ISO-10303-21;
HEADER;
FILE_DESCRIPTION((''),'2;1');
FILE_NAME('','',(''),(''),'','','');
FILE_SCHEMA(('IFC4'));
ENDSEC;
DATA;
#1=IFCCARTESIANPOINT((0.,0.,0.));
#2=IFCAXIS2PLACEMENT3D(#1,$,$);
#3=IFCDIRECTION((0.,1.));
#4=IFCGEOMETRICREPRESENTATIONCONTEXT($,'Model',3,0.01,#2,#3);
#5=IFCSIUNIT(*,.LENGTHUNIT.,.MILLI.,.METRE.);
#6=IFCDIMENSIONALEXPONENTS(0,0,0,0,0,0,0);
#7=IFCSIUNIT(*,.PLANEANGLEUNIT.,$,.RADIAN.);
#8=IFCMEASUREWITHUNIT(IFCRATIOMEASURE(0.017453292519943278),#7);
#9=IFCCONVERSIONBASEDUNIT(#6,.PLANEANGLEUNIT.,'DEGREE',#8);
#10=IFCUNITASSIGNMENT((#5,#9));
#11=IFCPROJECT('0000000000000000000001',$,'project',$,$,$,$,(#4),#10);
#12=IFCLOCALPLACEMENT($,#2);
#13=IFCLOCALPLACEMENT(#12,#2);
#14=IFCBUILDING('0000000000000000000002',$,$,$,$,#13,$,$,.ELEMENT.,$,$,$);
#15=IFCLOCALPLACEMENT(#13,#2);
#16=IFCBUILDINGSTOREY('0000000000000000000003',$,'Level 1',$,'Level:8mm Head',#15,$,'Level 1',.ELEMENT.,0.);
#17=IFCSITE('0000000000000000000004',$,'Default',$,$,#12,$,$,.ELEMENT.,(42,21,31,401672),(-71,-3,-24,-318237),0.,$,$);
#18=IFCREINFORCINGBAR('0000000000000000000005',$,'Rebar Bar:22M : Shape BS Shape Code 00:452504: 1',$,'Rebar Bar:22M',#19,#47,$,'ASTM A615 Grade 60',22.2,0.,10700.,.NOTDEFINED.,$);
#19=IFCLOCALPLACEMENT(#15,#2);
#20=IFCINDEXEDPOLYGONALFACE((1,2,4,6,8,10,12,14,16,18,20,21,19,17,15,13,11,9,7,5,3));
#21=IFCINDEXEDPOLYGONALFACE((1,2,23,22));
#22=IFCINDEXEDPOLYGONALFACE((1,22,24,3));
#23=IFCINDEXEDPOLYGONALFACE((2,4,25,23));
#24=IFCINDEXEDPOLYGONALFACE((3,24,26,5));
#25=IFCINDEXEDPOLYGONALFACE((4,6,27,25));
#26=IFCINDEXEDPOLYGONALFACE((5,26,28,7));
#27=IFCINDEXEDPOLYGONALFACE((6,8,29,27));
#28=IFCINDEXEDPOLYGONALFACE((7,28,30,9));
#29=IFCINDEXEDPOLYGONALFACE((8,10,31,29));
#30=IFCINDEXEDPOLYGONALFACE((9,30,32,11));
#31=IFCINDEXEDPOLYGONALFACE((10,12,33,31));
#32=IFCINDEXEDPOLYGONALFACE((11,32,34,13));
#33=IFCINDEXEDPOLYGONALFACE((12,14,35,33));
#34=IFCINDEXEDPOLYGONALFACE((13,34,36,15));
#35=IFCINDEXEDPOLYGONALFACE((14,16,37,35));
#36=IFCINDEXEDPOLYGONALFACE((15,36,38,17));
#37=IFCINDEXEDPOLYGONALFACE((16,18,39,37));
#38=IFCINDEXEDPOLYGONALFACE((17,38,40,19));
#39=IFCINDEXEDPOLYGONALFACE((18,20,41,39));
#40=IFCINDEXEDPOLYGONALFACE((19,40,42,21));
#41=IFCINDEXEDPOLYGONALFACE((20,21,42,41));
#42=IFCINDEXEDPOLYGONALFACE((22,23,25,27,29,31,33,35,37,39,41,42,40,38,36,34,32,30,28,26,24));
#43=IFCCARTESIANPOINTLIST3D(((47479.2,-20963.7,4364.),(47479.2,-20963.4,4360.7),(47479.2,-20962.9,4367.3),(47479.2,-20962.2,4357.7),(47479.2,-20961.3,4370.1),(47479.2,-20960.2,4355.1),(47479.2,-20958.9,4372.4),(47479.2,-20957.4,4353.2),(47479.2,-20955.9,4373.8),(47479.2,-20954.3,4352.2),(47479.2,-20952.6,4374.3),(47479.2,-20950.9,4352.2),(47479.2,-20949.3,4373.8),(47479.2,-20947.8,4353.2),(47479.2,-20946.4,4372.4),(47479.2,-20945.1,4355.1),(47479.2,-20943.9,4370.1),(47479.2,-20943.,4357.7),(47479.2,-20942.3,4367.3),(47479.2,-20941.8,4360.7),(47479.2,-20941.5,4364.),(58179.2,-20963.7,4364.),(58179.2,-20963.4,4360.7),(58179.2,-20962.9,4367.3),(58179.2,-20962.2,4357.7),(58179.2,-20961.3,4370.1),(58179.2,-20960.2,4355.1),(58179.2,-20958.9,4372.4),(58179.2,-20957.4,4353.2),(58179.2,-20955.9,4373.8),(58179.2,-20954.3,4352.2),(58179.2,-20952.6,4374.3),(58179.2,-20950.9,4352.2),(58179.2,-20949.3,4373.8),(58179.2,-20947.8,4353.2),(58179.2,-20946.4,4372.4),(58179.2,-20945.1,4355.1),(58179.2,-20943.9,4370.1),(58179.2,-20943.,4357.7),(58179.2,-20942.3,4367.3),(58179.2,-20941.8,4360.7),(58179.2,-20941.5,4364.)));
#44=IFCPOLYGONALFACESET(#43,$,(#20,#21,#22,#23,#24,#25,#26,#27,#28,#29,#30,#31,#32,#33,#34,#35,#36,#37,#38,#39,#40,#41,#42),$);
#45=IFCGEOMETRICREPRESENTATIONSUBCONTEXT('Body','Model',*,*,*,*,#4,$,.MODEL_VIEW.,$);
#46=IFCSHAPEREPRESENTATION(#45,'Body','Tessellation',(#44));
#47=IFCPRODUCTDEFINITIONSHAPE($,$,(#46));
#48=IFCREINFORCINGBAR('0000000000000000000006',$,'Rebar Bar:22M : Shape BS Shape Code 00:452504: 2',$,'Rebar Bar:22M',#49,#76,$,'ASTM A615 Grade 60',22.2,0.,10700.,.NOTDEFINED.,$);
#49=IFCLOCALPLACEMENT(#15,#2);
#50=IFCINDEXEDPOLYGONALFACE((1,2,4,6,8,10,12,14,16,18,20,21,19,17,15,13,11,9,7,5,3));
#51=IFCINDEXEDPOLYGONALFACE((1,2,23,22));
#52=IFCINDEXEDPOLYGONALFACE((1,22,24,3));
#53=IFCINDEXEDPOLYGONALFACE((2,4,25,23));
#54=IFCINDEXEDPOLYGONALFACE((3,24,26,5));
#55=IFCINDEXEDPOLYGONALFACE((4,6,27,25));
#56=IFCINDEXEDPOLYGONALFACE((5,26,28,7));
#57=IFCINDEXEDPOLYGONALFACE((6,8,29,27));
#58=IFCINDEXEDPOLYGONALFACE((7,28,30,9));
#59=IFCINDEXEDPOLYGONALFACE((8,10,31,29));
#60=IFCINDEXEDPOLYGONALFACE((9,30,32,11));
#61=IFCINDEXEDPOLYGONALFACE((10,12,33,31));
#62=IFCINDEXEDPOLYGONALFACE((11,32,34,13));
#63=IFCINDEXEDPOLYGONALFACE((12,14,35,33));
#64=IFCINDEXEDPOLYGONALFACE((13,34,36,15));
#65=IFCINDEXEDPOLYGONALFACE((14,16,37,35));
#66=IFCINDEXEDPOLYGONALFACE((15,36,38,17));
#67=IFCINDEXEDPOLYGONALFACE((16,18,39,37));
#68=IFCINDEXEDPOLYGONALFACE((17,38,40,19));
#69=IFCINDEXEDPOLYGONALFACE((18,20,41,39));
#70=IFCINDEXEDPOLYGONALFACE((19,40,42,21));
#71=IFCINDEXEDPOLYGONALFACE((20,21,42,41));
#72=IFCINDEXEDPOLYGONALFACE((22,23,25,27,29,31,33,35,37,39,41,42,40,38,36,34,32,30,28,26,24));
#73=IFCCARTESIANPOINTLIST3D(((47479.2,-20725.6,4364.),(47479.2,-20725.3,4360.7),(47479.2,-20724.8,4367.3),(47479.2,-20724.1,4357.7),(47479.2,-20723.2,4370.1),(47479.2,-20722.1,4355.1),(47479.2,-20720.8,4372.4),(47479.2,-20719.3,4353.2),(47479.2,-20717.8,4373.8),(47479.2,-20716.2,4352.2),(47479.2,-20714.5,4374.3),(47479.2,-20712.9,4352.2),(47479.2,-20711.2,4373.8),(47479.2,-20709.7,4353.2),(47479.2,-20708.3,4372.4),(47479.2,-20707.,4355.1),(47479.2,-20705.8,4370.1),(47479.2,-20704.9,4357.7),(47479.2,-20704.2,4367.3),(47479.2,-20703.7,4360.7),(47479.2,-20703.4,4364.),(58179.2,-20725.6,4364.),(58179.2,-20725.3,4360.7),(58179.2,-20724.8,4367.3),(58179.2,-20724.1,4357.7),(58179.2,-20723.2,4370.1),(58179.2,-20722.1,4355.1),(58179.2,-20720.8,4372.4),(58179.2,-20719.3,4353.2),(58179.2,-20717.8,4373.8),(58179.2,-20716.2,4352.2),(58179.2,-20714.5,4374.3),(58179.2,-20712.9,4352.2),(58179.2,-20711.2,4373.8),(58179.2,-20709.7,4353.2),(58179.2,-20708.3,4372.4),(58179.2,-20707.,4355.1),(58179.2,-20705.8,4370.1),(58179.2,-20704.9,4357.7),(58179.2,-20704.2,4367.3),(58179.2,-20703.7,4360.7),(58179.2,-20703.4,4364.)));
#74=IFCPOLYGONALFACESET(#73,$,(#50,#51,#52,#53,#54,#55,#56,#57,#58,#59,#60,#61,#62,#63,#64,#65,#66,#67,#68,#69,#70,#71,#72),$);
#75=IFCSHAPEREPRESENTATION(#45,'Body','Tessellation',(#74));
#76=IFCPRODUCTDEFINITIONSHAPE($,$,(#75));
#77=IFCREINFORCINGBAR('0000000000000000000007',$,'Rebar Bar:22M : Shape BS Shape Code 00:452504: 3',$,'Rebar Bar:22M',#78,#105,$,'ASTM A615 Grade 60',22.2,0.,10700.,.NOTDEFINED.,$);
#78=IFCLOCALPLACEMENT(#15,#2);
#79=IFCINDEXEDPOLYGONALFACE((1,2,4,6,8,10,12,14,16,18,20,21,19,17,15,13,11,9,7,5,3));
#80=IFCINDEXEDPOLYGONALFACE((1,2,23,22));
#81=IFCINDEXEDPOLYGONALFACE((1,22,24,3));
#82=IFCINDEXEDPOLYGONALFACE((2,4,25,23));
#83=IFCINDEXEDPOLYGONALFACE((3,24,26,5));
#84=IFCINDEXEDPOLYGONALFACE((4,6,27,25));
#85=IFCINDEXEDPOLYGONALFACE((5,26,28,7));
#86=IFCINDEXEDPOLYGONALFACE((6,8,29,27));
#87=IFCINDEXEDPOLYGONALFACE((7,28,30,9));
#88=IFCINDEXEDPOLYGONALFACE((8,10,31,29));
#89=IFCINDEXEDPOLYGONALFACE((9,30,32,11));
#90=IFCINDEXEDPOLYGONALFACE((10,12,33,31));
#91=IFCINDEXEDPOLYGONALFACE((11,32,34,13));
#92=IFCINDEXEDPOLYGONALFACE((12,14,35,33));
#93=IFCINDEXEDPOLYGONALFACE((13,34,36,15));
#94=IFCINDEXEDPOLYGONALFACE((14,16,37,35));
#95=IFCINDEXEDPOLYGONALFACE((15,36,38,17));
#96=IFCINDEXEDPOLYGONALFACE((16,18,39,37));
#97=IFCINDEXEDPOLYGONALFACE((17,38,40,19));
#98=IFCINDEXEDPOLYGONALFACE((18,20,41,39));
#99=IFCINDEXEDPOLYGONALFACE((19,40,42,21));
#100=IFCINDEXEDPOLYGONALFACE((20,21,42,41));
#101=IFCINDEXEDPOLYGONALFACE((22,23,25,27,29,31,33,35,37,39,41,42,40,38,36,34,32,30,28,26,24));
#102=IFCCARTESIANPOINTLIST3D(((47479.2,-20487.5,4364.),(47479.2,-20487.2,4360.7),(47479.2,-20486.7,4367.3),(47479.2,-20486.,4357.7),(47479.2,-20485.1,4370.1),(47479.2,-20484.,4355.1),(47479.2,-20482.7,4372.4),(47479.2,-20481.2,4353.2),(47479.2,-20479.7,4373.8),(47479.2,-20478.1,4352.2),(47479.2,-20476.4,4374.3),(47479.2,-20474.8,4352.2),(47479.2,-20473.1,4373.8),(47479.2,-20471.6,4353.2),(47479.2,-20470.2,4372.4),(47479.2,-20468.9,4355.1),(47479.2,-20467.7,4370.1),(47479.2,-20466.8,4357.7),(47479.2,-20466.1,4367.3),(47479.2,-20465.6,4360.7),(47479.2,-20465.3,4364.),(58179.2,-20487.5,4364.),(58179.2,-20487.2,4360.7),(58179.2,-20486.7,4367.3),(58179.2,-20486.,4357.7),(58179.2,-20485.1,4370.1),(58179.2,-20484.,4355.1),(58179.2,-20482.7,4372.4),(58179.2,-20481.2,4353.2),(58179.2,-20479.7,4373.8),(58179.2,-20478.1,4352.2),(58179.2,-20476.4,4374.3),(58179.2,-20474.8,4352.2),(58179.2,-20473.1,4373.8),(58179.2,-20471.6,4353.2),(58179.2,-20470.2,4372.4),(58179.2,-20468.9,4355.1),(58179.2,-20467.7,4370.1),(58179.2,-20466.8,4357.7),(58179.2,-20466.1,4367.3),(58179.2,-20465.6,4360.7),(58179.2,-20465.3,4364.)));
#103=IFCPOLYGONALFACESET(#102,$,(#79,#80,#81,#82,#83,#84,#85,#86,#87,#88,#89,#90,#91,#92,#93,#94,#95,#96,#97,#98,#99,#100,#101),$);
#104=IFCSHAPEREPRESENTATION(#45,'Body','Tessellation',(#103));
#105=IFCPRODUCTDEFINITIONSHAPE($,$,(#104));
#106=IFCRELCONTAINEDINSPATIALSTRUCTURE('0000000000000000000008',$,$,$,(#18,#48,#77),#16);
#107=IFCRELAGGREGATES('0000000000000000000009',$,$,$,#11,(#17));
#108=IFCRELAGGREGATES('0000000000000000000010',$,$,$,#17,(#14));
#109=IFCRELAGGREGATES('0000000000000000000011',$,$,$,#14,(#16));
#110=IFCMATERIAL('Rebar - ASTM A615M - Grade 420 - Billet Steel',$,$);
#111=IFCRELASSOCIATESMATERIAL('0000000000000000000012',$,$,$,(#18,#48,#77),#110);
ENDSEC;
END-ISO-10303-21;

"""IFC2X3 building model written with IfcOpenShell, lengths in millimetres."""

from ifc_helpers import new_model, entity, si_unit, converted_unit, direction, origin, place, context, subcontext, project, spatial, material, element, save


model = new_model("IFC2X3")

# Units and contexts
model_context = context("Model", 3, precision=0.01, world=origin(), true_north=direction((0.0, 1.0)))
body_context = subcontext(model_context, "Body", "Model", "MODEL_VIEW")
ifc_project = project(units=[si_unit("LENGTHUNIT", "METRE", prefix="MILLI"), converted_unit("PLANEANGLEUNIT", "DEGREE", entity("IfcRatioMeasure", 0.017453292519943278), si_unit("PLANEANGLEUNIT", "RADIAN"), dimensions=[0, 0, 0, 0, 0, 0, 0])], contexts=[model_context])

# Site, building, storey
site_placement = place(None, origin())
site = spatial("IfcSite", under=ifc_project, at=site_placement, Name="Default", CompositionType="ELEMENT", RefLatitude=(42, 21, 31, 401672), RefLongitude=(-71, -3, -24, -318237), RefElevation=0.0)
building_placement = place(site_placement, origin())
building = spatial("IfcBuilding", under=site, at=building_placement, CompositionType="ELEMENT")
storey_placement = place(building_placement, origin())
storey = spatial("IfcBuildingStorey", under=building, at=storey_placement, Name="Level 1", ObjectType="Level:8mm Head", LongName="Level 1", CompositionType="ELEMENT", Elevation=0.0)

# Reinforcing bars
ifc_material = material(Name="Rebar - ASTM A615M - Grade 420 - Billet Steel")
reinforcing_bar_1_placement = place(storey_placement, origin())
element("IfcReinforcingBar", 1, at=reinforcing_bar_1_placement, inside=storey, material=ifc_material, Name="Rebar Bar:22M : Shape BS Shape Code 00:452504: 1", SteelGrade="ASTM A615 Grade 60", ObjectType="Rebar Bar:22M", BarLength=10700.0, BarRole="NOTDEFINED", CrossSectionArea=0.0, NominalDiameter=22.2, context=body_context, shape_type="AdvancedSweptSolid", body=[
    entity("IfcSweptDiskSolid", entity("IfcCompositeCurve", [entity("IfcCompositeCurveSegment", "CONTINUOUS", True, entity("IfcPolyline", [entity("IfcCartesianPoint", [47479.2, -20952.6, 4363.2]), entity("IfcCartesianPoint", [58179.2, -20952.6, 4363.2])]))], False), 11.1, None, 0.0, 1.0),
])
reinforcing_bar_2_placement = place(storey_placement, origin())
element("IfcReinforcingBar", 2, at=reinforcing_bar_2_placement, inside=storey, material=ifc_material, Name="Rebar Bar:22M : Shape BS Shape Code 00:452504: 2", SteelGrade="ASTM A615 Grade 60", ObjectType="Rebar Bar:22M", BarLength=10700.0, BarRole="NOTDEFINED", CrossSectionArea=0.0, NominalDiameter=22.2, context=body_context, shape_type="AdvancedSweptSolid", body=[
    entity("IfcSweptDiskSolid", entity("IfcCompositeCurve", [entity("IfcCompositeCurveSegment", "CONTINUOUS", True, entity("IfcPolyline", [entity("IfcCartesianPoint", [47479.2, -20714.5, 4363.2]), entity("IfcCartesianPoint", [58179.2, -20714.5, 4363.2])]))], False), 11.1, None, 0.0, 1.0),
])
reinforcing_bar_3_placement = place(storey_placement, origin())
element("IfcReinforcingBar", 3, at=reinforcing_bar_3_placement, inside=storey, material=ifc_material, Name="Rebar Bar:22M : Shape BS Shape Code 00:452504: 3", SteelGrade="ASTM A615 Grade 60", ObjectType="Rebar Bar:22M", BarLength=10700.0, BarRole="NOTDEFINED", CrossSectionArea=0.0, NominalDiameter=22.2, context=body_context, shape_type="AdvancedSweptSolid", body=[
    entity("IfcSweptDiskSolid", entity("IfcCompositeCurve", [entity("IfcCompositeCurveSegment", "CONTINUOUS", True, entity("IfcPolyline", [entity("IfcCartesianPoint", [47479.2, -20476.4, 4363.2]), entity("IfcCartesianPoint", [58179.2, -20476.4, 4363.2])]))], False), 11.1, None, 0.0, 1.0),
])

save(model, "model.ifc")
